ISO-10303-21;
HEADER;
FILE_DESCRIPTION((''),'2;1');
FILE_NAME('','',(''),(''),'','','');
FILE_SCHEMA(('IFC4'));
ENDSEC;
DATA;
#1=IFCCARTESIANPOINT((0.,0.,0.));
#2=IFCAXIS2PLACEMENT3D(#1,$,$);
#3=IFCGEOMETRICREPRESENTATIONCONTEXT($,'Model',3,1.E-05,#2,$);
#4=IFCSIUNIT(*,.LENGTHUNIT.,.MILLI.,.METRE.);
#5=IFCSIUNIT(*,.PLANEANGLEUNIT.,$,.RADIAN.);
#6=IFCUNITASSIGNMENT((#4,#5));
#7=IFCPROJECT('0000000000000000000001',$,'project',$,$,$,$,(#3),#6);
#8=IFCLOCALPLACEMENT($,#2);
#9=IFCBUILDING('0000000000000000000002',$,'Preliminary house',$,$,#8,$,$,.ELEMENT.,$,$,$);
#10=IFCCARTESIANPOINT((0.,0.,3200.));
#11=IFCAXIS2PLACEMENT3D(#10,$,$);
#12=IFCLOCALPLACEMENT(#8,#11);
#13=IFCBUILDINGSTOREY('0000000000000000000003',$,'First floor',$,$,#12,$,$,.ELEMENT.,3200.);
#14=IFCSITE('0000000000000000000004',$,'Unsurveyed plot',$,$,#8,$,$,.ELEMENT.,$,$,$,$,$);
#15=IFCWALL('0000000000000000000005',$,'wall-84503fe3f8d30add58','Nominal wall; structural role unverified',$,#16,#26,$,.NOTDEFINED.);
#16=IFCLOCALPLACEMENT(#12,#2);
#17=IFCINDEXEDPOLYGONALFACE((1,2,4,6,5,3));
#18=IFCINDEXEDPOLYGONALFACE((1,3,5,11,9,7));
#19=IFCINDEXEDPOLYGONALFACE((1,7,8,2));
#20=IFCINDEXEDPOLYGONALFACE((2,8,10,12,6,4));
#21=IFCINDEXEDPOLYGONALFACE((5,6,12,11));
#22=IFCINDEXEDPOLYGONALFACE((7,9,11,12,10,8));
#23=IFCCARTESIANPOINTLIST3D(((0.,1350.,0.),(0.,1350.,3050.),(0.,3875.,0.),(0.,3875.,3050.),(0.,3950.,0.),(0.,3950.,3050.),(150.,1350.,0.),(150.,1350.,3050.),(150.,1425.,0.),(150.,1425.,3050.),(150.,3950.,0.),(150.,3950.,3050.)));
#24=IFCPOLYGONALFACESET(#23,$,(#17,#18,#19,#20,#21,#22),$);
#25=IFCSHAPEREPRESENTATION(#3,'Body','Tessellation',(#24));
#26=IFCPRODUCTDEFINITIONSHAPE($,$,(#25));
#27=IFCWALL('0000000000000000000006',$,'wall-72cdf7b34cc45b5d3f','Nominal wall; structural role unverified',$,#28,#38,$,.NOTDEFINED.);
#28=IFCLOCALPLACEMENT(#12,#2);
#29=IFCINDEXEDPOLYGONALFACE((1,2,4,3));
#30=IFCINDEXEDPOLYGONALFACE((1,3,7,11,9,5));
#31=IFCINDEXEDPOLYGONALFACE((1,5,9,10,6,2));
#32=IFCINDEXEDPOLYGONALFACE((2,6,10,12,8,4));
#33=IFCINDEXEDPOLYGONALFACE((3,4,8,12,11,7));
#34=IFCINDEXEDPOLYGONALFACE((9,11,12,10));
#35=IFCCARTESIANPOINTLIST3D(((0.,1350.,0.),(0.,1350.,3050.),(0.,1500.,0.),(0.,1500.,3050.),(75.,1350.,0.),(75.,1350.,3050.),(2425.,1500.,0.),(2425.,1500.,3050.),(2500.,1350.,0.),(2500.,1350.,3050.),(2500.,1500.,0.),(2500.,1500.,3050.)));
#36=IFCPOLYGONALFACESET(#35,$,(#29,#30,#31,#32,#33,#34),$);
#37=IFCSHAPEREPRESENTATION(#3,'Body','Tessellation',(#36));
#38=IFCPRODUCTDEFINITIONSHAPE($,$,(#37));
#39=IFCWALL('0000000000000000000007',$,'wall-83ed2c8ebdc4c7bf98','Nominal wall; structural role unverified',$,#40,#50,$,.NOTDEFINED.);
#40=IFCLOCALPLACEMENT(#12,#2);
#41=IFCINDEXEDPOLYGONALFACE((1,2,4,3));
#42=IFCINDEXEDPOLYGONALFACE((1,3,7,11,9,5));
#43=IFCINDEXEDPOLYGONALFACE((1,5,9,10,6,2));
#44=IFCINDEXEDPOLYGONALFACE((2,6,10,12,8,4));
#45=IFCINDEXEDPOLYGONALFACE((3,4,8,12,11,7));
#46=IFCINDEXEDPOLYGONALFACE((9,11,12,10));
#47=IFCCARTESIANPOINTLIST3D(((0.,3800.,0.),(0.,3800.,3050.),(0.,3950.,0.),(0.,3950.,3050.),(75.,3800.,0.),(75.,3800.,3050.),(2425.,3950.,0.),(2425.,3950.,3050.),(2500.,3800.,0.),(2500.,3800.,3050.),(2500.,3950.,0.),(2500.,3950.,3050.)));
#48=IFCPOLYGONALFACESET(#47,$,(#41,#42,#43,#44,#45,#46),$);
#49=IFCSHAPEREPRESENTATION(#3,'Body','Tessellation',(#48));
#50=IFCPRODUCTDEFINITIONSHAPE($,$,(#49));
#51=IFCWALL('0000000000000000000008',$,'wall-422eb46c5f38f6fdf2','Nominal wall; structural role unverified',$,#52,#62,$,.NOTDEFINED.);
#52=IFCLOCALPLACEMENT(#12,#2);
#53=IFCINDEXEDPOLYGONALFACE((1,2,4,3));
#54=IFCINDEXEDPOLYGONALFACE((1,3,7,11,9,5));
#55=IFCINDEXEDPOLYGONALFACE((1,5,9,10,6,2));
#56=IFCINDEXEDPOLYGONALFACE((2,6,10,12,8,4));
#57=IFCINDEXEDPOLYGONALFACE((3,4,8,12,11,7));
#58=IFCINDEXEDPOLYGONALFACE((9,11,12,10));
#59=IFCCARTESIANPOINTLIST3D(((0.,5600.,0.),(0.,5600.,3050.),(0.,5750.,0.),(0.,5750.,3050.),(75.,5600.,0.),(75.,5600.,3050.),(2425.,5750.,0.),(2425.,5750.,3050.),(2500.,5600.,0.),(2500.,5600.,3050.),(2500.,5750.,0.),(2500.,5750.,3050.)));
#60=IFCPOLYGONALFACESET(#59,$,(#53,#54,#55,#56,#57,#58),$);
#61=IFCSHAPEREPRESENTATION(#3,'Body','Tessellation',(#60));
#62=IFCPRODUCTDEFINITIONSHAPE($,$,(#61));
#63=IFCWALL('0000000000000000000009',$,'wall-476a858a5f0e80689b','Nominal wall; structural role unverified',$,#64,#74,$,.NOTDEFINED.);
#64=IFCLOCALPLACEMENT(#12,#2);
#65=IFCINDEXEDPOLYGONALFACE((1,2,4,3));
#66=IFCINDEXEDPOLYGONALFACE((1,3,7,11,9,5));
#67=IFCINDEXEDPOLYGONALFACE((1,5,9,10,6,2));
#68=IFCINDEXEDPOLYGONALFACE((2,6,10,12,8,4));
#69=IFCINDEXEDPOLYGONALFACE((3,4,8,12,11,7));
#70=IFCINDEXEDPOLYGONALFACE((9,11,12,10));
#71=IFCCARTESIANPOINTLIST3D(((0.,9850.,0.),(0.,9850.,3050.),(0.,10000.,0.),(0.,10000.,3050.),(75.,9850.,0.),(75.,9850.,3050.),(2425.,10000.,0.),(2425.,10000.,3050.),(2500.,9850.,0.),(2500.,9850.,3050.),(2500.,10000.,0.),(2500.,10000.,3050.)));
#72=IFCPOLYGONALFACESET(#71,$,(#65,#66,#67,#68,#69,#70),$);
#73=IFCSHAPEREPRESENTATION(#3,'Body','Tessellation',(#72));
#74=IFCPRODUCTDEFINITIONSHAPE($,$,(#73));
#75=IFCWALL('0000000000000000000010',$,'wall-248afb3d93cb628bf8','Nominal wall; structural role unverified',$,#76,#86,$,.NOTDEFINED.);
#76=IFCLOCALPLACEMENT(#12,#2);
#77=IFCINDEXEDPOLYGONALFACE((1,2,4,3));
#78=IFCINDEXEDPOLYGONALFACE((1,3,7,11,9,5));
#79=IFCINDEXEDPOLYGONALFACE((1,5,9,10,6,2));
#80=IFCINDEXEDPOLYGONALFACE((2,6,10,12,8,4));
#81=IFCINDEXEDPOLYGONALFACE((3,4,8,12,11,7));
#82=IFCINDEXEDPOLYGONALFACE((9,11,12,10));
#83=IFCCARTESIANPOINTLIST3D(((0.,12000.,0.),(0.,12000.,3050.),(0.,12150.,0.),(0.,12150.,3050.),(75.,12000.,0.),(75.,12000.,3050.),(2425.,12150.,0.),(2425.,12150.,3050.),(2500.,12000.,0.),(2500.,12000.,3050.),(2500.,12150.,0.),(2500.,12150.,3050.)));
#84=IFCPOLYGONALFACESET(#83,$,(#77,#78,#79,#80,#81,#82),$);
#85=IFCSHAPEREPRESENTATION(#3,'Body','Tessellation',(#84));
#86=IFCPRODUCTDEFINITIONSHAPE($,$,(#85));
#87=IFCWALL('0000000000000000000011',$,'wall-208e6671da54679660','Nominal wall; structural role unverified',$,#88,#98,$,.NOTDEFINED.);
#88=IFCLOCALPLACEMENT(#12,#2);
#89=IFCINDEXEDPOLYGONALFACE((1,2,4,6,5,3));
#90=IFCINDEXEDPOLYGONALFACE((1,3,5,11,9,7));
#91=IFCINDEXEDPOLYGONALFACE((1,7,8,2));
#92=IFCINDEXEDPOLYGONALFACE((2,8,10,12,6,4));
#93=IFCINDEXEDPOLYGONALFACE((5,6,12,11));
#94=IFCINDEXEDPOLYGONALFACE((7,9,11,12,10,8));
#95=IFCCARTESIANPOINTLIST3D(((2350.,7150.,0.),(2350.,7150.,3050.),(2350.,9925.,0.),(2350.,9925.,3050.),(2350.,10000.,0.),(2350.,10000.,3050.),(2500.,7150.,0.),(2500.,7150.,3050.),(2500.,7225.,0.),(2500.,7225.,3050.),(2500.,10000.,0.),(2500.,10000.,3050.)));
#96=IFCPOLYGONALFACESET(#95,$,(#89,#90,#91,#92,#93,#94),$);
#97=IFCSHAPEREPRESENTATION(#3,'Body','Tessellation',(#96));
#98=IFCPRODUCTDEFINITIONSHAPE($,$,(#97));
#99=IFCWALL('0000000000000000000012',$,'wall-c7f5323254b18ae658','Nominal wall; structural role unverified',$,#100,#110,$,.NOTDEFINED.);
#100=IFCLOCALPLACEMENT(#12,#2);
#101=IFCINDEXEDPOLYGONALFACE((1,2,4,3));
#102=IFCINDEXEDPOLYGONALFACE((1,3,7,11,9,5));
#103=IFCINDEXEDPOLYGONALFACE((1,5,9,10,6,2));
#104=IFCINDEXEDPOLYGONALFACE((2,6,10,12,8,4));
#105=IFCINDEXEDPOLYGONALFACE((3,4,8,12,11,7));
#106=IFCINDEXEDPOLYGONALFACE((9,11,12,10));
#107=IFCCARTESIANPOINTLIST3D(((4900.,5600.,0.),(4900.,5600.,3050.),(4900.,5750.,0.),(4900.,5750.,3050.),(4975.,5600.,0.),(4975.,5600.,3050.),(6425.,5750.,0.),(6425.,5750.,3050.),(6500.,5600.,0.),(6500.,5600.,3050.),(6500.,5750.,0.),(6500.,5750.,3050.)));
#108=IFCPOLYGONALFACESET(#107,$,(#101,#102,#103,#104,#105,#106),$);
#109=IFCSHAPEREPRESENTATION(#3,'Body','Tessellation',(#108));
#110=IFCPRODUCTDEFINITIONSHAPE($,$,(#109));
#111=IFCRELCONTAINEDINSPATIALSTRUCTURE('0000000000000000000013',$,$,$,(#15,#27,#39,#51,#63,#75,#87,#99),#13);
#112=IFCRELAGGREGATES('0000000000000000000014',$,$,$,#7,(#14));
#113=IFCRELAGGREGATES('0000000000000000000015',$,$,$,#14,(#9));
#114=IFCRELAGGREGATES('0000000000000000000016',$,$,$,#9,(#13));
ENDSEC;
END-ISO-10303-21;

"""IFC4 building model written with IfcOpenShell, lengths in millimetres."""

from ifc_helpers import new_model, si_unit, frame, origin, place, context, project, spatial, polyline, outline, extrude, element, save


model = new_model("IFC4")

# Units and contexts
model_context = context("Model", 3, precision=1e-05, world=origin())
ifc_project = project(units=[si_unit("LENGTHUNIT", "METRE", prefix="MILLI"), si_unit("PLANEANGLEUNIT", "RADIAN")], contexts=[model_context])

# Site, building, storey
placement_1 = place(None, origin())
site = spatial("IfcSite", under=ifc_project, at=placement_1, Name="Unsurveyed plot", CompositionType="ELEMENT")
building = spatial("IfcBuilding", under=site, at=placement_1, Name="Preliminary house", CompositionType="ELEMENT")
placement_2 = place(placement_1, frame((0.0, 0.0, 3200.0)))
storey = spatial("IfcBuildingStorey", under=building, at=placement_2, Name="First floor", CompositionType="ELEMENT", Elevation=3200.0)

# Walls
element("IfcWall", 1, at=placement_2, inside=storey, Name="wall-84503fe3f8d30add58", Description="Nominal wall; structural role unverified", PredefinedType="NOTDEFINED", context=model_context, shape_type="SweptSolid", body=[
    extrude(outline(polyline([(0.0, 3875.0), (0.0, 3950.0), (150.0, 3950.0), (150.0, 1425.0), (150.0, 1350.0), (0.0, 1350.0), (0.0, 3875.0)])), origin(), (0.0, 0.0, 1.0), 3050.0),
])
element("IfcWall", 2, at=placement_2, inside=storey, Name="wall-72cdf7b34cc45b5d3f", Description="Nominal wall; structural role unverified", PredefinedType="NOTDEFINED", context=model_context, shape_type="SweptSolid", body=[
    extrude(outline(polyline([(2425.0, 1500.0), (2500.0, 1500.0), (2500.0, 1350.0), (75.0, 1350.0), (0.0, 1350.0), (0.0, 1500.0), (2425.0, 1500.0)])), origin(), (0.0, 0.0, 1.0), 3050.0),
])

# Wall
element("IfcWall", 3, at=placement_2, inside=storey, Name="wall-83ed2c8ebdc4c7bf98", Description="Nominal wall; structural role unverified", PredefinedType="NOTDEFINED", context=model_context, shape_type="SweptSolid", body=[
    extrude(outline(polyline([(2425.0, 3950.0), (2500.0, 3950.0), (2500.0, 3800.0), (75.0, 3800.0), (0.0, 3800.0), (0.0, 3950.0), (2425.0, 3950.0)])), origin(), (0.0, 0.0, 1.0), 3050.0),
])

# Wall
element("IfcWall", 4, at=placement_2, inside=storey, Name="wall-422eb46c5f38f6fdf2", Description="Nominal wall; structural role unverified", PredefinedType="NOTDEFINED", context=model_context, shape_type="SweptSolid", body=[
    extrude(outline(polyline([(2425.0, 5750.0), (2500.0, 5750.0), (2500.0, 5600.0), (75.0, 5600.0), (0.0, 5600.0), (0.0, 5750.0), (2425.0, 5750.0)])), origin(), (0.0, 0.0, 1.0), 3050.0),
])

# Walls
element("IfcWall", 5, at=placement_2, inside=storey, Name="wall-476a858a5f0e80689b", Description="Nominal wall; structural role unverified", PredefinedType="NOTDEFINED", context=model_context, shape_type="SweptSolid", body=[
    extrude(outline(polyline([(2425.0, 10000.0), (2500.0, 10000.0), (2500.0, 9850.0), (75.0, 9850.0), (0.0, 9850.0), (0.0, 10000.0), (2425.0, 10000.0)])), origin(), (0.0, 0.0, 1.0), 3050.0),
])
element("IfcWall", 6, at=placement_2, inside=storey, Name="wall-248afb3d93cb628bf8", Description="Nominal wall; structural role unverified", PredefinedType="NOTDEFINED", context=model_context, shape_type="SweptSolid", body=[
    extrude(outline(polyline([(2425.0, 12150.0), (2500.0, 12150.0), (2500.0, 12000.0), (75.0, 12000.0), (0.0, 12000.0), (0.0, 12150.0), (2425.0, 12150.0)])), origin(), (0.0, 0.0, 1.0), 3050.0),
])

# Wall
element("IfcWall", 7, at=placement_2, inside=storey, Name="wall-208e6671da54679660", Description="Nominal wall; structural role unverified", PredefinedType="NOTDEFINED", context=model_context, shape_type="SweptSolid", body=[
    extrude(outline(polyline([(2350.0, 9925.0), (2350.0, 10000.0), (2500.0, 10000.0), (2500.0, 7225.0), (2500.0, 7150.0), (2350.0, 7150.0), (2350.0, 9925.0)])), origin(), (0.0, 0.0, 1.0), 3050.0),
])

# Wall
element("IfcWall", 8, at=placement_2, inside=storey, Name="wall-c7f5323254b18ae658", Description="Nominal wall; structural role unverified", PredefinedType="NOTDEFINED", context=model_context, shape_type="SweptSolid", body=[
    extrude(outline(polyline([(6425.0, 5750.0), (6500.0, 5750.0), (6500.0, 5600.0), (4975.0, 5600.0), (4900.0, 5600.0), (4900.0, 5750.0), (6425.0, 5750.0)])), origin(), (0.0, 0.0, 1.0), 3050.0),
])

save(model, "model.ifc")
